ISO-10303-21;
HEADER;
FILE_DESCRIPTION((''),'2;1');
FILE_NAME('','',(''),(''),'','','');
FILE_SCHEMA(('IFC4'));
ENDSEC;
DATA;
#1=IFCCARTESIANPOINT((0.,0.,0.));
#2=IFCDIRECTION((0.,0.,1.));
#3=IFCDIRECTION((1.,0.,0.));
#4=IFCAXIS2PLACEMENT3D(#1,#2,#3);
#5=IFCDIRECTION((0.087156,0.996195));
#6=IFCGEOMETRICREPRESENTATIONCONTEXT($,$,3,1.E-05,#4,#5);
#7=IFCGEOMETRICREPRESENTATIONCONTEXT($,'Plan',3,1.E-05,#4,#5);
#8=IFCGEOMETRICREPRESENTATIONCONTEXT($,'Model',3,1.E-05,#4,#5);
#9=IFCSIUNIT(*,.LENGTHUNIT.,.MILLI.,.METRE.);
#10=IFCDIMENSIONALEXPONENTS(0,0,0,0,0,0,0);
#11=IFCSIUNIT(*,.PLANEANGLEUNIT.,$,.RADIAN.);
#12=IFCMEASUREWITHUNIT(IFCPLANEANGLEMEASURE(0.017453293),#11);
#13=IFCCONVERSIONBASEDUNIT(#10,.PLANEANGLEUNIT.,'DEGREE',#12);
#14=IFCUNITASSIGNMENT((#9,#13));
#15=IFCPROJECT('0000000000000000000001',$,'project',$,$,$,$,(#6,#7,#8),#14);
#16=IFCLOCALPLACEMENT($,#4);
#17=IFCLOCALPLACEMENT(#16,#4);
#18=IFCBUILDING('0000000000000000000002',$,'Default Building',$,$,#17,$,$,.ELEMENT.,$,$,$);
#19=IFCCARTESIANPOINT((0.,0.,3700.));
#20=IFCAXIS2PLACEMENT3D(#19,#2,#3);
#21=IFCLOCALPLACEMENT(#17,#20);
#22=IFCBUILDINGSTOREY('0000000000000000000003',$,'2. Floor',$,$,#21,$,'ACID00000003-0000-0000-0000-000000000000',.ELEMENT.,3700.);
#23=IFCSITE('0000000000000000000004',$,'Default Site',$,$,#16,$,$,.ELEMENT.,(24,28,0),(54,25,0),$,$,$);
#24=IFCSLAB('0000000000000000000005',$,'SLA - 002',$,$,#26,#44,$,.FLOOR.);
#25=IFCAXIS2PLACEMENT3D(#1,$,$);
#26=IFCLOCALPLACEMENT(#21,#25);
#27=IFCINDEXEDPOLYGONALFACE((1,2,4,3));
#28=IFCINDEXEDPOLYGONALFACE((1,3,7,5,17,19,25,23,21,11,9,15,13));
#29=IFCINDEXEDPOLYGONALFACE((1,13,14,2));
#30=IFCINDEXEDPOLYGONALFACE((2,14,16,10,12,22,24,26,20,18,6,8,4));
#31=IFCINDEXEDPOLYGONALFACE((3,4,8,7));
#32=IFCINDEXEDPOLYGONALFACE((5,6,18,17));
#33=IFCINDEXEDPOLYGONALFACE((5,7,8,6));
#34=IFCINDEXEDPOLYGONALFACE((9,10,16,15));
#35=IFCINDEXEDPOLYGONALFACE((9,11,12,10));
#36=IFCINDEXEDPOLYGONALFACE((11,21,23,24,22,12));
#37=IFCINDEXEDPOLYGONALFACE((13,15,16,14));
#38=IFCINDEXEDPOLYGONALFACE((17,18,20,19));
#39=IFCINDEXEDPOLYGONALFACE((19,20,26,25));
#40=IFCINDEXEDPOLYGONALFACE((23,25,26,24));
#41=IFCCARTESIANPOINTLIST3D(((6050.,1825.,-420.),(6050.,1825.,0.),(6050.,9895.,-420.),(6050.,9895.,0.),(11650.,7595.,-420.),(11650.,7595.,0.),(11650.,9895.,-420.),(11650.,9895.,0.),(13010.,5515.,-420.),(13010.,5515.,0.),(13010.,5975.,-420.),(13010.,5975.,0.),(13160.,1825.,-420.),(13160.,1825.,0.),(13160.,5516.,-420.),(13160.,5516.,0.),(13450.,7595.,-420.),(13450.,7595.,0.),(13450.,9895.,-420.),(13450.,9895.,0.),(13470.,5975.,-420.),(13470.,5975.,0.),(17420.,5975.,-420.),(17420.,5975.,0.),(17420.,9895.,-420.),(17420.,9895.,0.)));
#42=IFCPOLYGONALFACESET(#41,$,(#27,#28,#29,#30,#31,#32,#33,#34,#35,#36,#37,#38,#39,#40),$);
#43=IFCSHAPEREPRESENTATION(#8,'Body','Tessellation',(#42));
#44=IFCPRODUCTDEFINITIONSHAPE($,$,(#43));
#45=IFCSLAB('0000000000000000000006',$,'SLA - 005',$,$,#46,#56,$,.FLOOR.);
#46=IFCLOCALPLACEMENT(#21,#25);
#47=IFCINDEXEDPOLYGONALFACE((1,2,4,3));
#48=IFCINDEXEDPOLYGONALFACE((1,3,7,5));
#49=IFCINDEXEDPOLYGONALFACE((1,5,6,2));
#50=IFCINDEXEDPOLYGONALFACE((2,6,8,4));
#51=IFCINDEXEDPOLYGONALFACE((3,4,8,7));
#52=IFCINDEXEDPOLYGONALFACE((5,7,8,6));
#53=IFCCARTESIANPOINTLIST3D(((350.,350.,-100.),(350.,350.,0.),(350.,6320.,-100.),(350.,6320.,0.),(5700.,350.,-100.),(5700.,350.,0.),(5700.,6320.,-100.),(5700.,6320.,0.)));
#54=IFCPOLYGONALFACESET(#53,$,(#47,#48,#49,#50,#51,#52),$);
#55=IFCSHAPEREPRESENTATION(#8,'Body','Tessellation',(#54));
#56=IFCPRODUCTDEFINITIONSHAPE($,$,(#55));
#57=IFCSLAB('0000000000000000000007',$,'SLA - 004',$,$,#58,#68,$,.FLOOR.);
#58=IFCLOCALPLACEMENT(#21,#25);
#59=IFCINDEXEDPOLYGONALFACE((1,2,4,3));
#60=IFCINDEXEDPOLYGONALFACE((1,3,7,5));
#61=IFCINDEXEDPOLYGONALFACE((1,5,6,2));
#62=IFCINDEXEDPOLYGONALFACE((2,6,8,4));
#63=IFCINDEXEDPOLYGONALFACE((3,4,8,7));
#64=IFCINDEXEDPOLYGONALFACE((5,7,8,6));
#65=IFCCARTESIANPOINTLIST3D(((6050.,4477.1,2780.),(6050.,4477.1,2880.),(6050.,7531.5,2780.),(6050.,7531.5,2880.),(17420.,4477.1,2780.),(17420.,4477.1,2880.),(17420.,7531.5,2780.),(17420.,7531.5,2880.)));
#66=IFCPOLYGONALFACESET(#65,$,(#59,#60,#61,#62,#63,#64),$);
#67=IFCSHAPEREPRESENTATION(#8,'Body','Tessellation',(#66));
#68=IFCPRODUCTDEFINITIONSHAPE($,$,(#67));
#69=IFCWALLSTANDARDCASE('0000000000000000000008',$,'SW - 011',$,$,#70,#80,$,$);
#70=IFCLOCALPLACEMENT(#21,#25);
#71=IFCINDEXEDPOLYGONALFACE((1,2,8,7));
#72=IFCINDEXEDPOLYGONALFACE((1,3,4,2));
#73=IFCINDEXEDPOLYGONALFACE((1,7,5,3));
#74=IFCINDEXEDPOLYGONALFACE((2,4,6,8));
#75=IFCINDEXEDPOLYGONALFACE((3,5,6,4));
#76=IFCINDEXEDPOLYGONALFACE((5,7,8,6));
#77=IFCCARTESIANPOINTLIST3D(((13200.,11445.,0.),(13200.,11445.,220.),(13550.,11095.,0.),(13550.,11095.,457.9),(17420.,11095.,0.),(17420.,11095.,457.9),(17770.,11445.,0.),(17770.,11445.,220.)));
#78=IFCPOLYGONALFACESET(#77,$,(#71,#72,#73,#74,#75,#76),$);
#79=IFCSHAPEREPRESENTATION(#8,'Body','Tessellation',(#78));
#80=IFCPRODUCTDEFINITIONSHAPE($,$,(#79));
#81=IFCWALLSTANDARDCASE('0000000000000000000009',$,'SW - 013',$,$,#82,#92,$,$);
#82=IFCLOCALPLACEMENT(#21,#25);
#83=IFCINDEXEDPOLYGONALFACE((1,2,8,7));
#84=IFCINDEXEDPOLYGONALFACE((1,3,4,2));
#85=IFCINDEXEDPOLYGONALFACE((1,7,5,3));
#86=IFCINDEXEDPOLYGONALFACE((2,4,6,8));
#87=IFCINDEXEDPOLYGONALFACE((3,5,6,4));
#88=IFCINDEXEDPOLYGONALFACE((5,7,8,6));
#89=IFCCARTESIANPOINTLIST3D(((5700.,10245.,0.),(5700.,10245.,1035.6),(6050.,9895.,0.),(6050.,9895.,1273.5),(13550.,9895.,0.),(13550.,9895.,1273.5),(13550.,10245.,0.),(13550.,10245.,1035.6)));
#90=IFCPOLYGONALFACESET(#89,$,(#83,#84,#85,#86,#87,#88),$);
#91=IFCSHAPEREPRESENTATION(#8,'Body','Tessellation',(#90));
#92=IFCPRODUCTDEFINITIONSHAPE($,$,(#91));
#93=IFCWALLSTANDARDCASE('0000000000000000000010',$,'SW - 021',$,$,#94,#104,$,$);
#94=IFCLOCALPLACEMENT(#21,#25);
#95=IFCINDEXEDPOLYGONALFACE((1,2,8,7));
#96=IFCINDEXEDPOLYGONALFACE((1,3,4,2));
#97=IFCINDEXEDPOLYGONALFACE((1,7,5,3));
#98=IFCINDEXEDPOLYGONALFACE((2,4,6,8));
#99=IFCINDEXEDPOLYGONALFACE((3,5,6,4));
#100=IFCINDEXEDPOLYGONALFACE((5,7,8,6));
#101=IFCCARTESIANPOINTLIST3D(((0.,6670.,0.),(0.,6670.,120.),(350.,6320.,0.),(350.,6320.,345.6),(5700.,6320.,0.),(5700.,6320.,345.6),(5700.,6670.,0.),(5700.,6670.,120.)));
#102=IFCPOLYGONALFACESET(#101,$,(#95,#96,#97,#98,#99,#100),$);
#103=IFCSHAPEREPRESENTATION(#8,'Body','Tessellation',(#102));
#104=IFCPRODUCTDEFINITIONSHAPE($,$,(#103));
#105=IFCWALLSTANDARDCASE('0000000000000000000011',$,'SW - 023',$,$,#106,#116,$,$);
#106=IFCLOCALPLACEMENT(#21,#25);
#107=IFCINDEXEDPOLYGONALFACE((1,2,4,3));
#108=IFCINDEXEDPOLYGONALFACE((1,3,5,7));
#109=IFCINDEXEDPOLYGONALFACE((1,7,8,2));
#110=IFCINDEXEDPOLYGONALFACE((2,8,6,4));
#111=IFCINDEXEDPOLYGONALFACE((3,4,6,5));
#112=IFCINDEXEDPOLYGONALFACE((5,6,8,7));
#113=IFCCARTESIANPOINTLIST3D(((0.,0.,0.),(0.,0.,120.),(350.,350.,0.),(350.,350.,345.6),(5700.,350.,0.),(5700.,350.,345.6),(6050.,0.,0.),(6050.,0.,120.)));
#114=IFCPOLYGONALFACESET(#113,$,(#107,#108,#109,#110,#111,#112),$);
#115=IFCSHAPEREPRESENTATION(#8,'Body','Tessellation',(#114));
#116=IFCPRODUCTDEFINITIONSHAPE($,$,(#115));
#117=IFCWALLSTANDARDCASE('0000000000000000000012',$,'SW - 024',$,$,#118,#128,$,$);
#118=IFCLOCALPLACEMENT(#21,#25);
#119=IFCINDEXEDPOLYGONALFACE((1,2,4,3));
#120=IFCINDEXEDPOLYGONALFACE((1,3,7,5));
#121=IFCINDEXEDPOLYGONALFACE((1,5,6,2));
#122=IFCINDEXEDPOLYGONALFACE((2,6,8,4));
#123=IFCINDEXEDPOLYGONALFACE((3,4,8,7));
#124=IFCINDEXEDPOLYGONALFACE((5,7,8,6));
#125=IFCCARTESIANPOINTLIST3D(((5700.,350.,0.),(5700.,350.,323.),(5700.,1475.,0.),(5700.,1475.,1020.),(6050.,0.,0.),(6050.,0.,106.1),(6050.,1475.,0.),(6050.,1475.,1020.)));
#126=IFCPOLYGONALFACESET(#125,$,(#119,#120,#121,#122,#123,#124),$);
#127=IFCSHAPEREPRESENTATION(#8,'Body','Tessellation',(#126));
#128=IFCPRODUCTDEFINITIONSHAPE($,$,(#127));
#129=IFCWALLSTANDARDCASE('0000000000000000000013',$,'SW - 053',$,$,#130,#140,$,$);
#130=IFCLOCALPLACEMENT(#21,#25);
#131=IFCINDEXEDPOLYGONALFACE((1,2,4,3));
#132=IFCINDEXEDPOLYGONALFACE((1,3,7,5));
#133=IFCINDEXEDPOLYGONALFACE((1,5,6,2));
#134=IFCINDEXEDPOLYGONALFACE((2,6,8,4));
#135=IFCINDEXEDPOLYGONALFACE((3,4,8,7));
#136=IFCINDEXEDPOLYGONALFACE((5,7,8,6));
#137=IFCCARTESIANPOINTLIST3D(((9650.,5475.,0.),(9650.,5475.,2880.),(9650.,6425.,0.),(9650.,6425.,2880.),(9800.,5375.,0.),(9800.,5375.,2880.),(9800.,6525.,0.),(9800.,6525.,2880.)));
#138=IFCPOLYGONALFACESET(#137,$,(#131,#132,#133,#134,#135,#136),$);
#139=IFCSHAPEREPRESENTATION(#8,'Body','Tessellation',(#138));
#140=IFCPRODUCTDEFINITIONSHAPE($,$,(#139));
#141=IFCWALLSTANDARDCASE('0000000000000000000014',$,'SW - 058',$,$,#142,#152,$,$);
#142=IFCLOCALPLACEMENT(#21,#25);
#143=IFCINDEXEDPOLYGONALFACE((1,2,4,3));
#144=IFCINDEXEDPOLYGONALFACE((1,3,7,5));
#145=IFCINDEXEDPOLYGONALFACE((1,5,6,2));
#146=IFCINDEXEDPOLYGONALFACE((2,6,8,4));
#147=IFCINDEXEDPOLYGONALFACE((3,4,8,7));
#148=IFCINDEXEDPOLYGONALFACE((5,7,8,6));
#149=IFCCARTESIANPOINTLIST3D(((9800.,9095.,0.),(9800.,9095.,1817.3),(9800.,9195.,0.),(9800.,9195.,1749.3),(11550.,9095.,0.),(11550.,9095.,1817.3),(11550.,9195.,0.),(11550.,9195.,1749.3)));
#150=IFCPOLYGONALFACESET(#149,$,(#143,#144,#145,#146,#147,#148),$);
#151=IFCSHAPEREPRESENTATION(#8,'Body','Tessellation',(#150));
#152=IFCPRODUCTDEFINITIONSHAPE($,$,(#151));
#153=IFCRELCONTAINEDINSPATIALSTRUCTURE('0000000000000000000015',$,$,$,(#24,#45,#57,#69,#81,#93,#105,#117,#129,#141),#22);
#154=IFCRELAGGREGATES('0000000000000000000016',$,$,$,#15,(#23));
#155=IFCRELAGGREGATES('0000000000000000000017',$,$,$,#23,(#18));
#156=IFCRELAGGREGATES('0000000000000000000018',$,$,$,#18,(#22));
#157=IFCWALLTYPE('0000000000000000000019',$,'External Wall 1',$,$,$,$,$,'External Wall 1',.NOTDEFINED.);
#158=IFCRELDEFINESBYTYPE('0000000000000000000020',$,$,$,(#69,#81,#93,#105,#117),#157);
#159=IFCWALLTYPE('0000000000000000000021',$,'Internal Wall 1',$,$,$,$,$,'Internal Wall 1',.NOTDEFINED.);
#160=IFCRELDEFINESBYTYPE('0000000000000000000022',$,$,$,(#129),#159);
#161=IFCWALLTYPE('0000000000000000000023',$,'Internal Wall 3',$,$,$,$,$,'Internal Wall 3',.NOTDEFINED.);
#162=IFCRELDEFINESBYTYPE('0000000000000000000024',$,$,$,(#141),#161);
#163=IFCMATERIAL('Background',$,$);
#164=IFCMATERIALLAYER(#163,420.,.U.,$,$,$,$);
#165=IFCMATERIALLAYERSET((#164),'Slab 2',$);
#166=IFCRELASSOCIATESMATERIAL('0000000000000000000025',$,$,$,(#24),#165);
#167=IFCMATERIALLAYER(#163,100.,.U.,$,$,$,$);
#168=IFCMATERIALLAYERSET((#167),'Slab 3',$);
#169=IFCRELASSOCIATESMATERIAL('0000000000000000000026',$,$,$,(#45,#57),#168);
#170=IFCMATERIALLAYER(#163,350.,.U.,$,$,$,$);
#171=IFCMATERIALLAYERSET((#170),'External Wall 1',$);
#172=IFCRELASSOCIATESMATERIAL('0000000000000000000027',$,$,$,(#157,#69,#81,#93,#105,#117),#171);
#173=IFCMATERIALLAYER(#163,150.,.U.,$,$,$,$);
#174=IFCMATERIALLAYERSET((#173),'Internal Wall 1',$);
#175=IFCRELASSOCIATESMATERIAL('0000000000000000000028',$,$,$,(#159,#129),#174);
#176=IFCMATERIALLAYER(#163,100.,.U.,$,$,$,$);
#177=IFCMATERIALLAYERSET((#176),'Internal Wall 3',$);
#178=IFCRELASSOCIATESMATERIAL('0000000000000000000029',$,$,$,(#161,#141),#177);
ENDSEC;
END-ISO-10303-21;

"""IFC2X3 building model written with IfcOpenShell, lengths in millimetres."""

from ifc_helpers import new_model, entity, si_unit, converted_unit, direction, frame, origin_with_axes, place, context, project, spatial, polyline, outline, extrude, clip, halfspace, material, layer, layer_set, layer_usage, type_object, element, save


model = new_model("IFC2X3")

# Units and contexts
context_of_model = context(None, 3, precision=1e-05, world=origin_with_axes(), true_north=direction((0.087156, 0.996195)))
plan_context = context("Plan", 3, precision=1e-05, world=origin_with_axes(), true_north=direction((0.087156, 0.996195)))
model_context = context("Model", 3, precision=1e-05, world=origin_with_axes(), true_north=direction((0.087156, 0.996195)))
ifc_project = project(units=[si_unit("LENGTHUNIT", "METRE", prefix="MILLI"), converted_unit("PLANEANGLEUNIT", "DEGREE", entity("IfcPlaneAngleMeasure", 0.017453293), si_unit("PLANEANGLEUNIT", "RADIAN"), dimensions=[0, 0, 0, 0, 0, 0, 0])], contexts=[context_of_model, plan_context, model_context])

# Site, building, storey
site_placement = place(None, origin_with_axes())
site = spatial("IfcSite", under=ifc_project, at=site_placement, Name="Default Site", CompositionType="ELEMENT", RefLatitude=(24, 28, 0), RefLongitude=(54, 25, 0))
building_placement = place(site_placement, origin_with_axes())
building = spatial("IfcBuilding", under=site, at=building_placement, Name="Default Building", CompositionType="ELEMENT")
storey_placement = place(building_placement, frame((0.0, 0.0, 3700.0), z_axis=(0.0, 0.0, 1.0), x_axis=(1.0, 0.0, 0.0)))
storey = spatial("IfcBuildingStorey", under=building, at=storey_placement, Name="2. Floor", LongName="ACID00000003-0000-0000-0000-000000000000", CompositionType="ELEMENT", Elevation=3700.0)

# Slabs
ifc_material = material(Name="Background")
ifc_layer_1 = layer(ifc_material, 420.0, ventilated="UNKNOWN")
ifc_layer_set_1 = layer_set([ifc_layer_1], Name="Slab 2")
ifc_layer_usage_1 = layer_usage(ifc_layer_set_1, "AXIS3", "NEGATIVE", 420.0)
slab_1_placement = place(storey_placement, frame((13470.0, 5975.0, -420.0), z_axis=(0.0, 0.0, 1.0), x_axis=(1.0, 0.0, 0.0)))
element("IfcSlab", 1, at=slab_1_placement, inside=storey, material=ifc_layer_usage_1, Name="SLA - 002", PredefinedType="FLOOR", context=model_context, shape_type="SweptSolid", body=[
    extrude(outline(polyline([(0.0, 0.0), (3950.0, 0.0), (3950.0, 3920.0), (-20.0, 3920.0), (-20.0, 1620.0), (-1820.0, 1620.0), (-1820.0, 3920.0), (-7420.0, 3920.0), (-7420.0, -4150.0), (-310.0, -4150.0), (-310.0, -459.0), (-460.0, -460.0), (-460.0, 0.0), (0.0, 0.0)])), origin_with_axes(), (0.0, 0.0, 1.0), 420.0),
])
ifc_layer_2 = layer(ifc_material, 100.0, ventilated="UNKNOWN")
ifc_layer_set_2 = layer_set([ifc_layer_2], Name="Slab 3")
ifc_layer_usage_2 = layer_usage(ifc_layer_set_2, "AXIS3", "NEGATIVE", 100.0)
slab_2_placement = place(storey_placement, frame((5700.0, 6320.0, -100.0), z_axis=(0.0, 0.0, 1.0), x_axis=(0.0, -1.0, 0.0)))
element("IfcSlab", 2, at=slab_2_placement, inside=storey, material=ifc_layer_usage_2, Name="SLA - 005", PredefinedType="FLOOR", context=model_context, shape_type="SweptSolid", body=[
    extrude(outline(polyline([(0.0, 0.0), (5970.0, 0.0), (5970.0, -5350.0), (0.0, -5350.0), (0.0, 0.0)])), origin_with_axes(), (0.0, 0.0, 1.0), 100.0),
])
ifc_layer_usage_3 = layer_usage(ifc_layer_set_2, "AXIS3", "NEGATIVE", 100.0)
slab_3_placement = place(storey_placement, frame((6050.0, 7531.5, 2780.0), z_axis=(0.0, 0.0, 1.0), x_axis=(0.0, -1.0, 0.0)))
element("IfcSlab", 3, at=slab_3_placement, inside=storey, material=ifc_layer_usage_3, Name="SLA - 004", PredefinedType="FLOOR", context=model_context, shape_type="SweptSolid", body=[
    extrude(outline(polyline([(0.0, 0.0), (3054.4, 0.0), (3054.4, 11370.0), (0.0, 11370.0), (0.0, 0.0)])), origin_with_axes(), (0.0, 0.0, 1.0), 100.0),
])

# Walls
ifc_layer_3 = layer(ifc_material, 350.0, ventilated="UNKNOWN")
ifc_layer_set_3 = layer_set([ifc_layer_3], Name="External Wall 1")
ifc_layer_usage_4 = layer_usage(ifc_layer_set_3, "AXIS2", "POSITIVE", 0.0)
wall_type_1 = type_object("IfcWallType", Name="External Wall 1", ElementType="External Wall 1", PredefinedType="NOTDEFINED", material=ifc_layer_set_3)
wall_1_placement = place(storey_placement, frame((17770.0, 11445.0, 0.0), z_axis=(0.0, 0.0, 1.0), x_axis=(-1.0, 0.0, 0.0)))
element("IfcWallStandardCase", 4, at=wall_1_placement, inside=storey, type_object=wall_type_1, material=ifc_layer_usage_4, Name="SW - 011", context=model_context, shape_type="Clipping", body=[
    clip(clip(extrude(outline(polyline([(0.0, 0.0), (4570.0, 0.0), (4220.0, 350.0), (350.0, 350.0), (0.0, 0.0)])), origin_with_axes(), (0.0, 0.0, 1.0), 457.9), halfspace(frame((0.0, -102.3, 150.5), z_axis=(0.0, -0.562142, 0.827041), x_axis=(0.0, 0.827041, 0.562142)), False)), halfspace(frame((0.0, -102.3, 150.5), z_axis=(0.0, -0.562142, 0.827041), x_axis=(0.0, 0.827041, 0.562142)), False)),
])
ifc_layer_usage_5 = layer_usage(ifc_layer_set_3, "AXIS2", "POSITIVE", 0.0)
wall_2_placement = place(storey_placement, frame((13550.0, 10245.0, 0.0), z_axis=(0.0, 0.0, 1.0), x_axis=(-1.0, 0.0, 0.0)))
element("IfcWallStandardCase", 5, at=wall_2_placement, inside=storey, type_object=wall_type_1, material=ifc_layer_usage_5, Name="SW - 013", context=model_context, shape_type="Clipping", body=[
    clip(clip(extrude(outline(polyline([(0.0, 0.0), (7850.0, 0.0), (7500.0, 350.0), (0.0, 350.0), (0.0, 0.0)])), origin_with_axes(), (0.0, 0.0, 1.0), 1273.5), halfspace(frame((0.0, -481.5, 708.4), z_axis=(0.0, -0.562142, 0.827041), x_axis=(0.0, 0.827041, 0.562142)), False)), halfspace(frame((0.0, -481.5, 708.4), z_axis=(0.0, -0.562142, 0.827041), x_axis=(0.0, 0.827041, 0.562142)), False)),
])

# Walls
ifc_layer_usage_6 = layer_usage(ifc_layer_set_3, "AXIS2", "POSITIVE", 0.0)
wall_3_placement = place(storey_placement, frame((5700.0, 6670.0, 0.0), z_axis=(0.0, 0.0, 1.0), x_axis=(-1.0, 0.0, 0.0)))
element("IfcWallStandardCase", 6, at=wall_3_placement, inside=storey, type_object=wall_type_1, material=ifc_layer_usage_6, Name="SW - 021", context=model_context, shape_type="Clipping", body=[
    clip(extrude(outline(polyline([(0.0, 0.0), (5700.0, 0.0), (5350.0, 350.0), (0.0, 350.0), (0.0, 0.0)])), origin_with_axes(), (0.0, 0.0, 1.0), 345.6), halfspace(frame((0.0, -54.6, 84.8), z_axis=(0.0, -0.54184, 0.840482), x_axis=(0.0, 0.840482, 0.54184)), False)),
])
ifc_layer_usage_7 = layer_usage(ifc_layer_set_3, "AXIS2", "POSITIVE", 0.0)
wall_4_placement = place(storey_placement, origin_with_axes())
element("IfcWallStandardCase", 7, at=wall_4_placement, inside=storey, type_object=wall_type_1, material=ifc_layer_usage_7, Name="SW - 023", context=model_context, shape_type="Clipping", body=[
    clip(extrude(outline(polyline([(0.0, 0.0), (6050.0, 0.0), (5700.0, 350.0), (350.0, 350.0), (0.0, 0.0)])), origin_with_axes(), (0.0, 0.0, 1.0), 345.6), halfspace(frame((0.0, -54.6, 84.8), z_axis=(0.0, -0.54184, 0.840482), x_axis=(0.0, 0.840482, 0.54184)), False)),
])
ifc_layer_usage_8 = layer_usage(ifc_layer_set_3, "AXIS2", "POSITIVE", 0.0)
wall_5_placement = place(storey_placement, frame((6050.0, 0.0, 0.0), z_axis=(0.0, 0.0, 1.0), x_axis=(0.0, 1.0, 0.0)))
element("IfcWallStandardCase", 8, at=wall_5_placement, inside=storey, type_object=wall_type_1, material=ifc_layer_usage_8, Name="SW - 024", context=model_context, shape_type="Clipping", body=[
    clip(extrude(outline(polyline([(0.0, 0.0), (1475.0, 0.0), (1475.0, 350.0), (350.0, 350.0), (0.0, 0.0)])), origin_with_axes(), (0.0, 0.0, 1.0), 1020.0), halfspace(frame((-47.5, 0.0, 76.7), z_axis=(-0.526673, 0.0, 0.850068), x_axis=(0.0, 1.0, 0.0)), False)),
])
ifc_layer_4 = layer(ifc_material, 150.0, ventilated="UNKNOWN")
ifc_layer_set_4 = layer_set([ifc_layer_4], Name="Internal Wall 1")
wall_type_2 = type_object("IfcWallType", Name="Internal Wall 1", ElementType="Internal Wall 1", PredefinedType="NOTDEFINED", material=ifc_layer_set_4)
ifc_layer_usage_9 = layer_usage(ifc_layer_set_4, "AXIS2", "POSITIVE", 0.0)
wall_6_placement = place(storey_placement, frame((9800.0, 5375.0, 0.0), z_axis=(0.0, 0.0, 1.0), x_axis=(0.0, 1.0, 0.0)))
element("IfcWallStandardCase", 9, at=wall_6_placement, inside=storey, type_object=wall_type_2, material=ifc_layer_usage_9, Name="SW - 053", context=model_context, shape_type="SweptSolid", body=[
    extrude(outline(polyline([(0.0, 0.0), (1150.0, 0.0), (1050.0, 150.0), (100.0, 150.0), (0.0, 0.0)])), origin_with_axes(), (0.0, 0.0, 1.0), 2880.0),
])
ifc_layer_5 = layer(ifc_material, 100.0, ventilated="UNKNOWN")
ifc_layer_set_5 = layer_set([ifc_layer_5], Name="Internal Wall 3")
ifc_layer_usage_10 = layer_usage(ifc_layer_set_5, "AXIS2", "NEGATIVE", 0.0)
wall_type_3 = type_object("IfcWallType", Name="Internal Wall 3", ElementType="Internal Wall 3", PredefinedType="NOTDEFINED", material=ifc_layer_set_5)
wall_7_placement = place(storey_placement, frame((11550.0, 9095.0, 0.0), z_axis=(0.0, 0.0, 1.0), x_axis=(-1.0, 0.0, 0.0)))
element("IfcWallStandardCase", 10, at=wall_7_placement, inside=storey, type_object=wall_type_3, material=ifc_layer_usage_10, Name="SW - 058", context=model_context, shape_type="Clipping", body=[
    clip(clip(extrude(outline(polyline([(0.0, -100.0), (1750.0, -100.0), (1750.0, 0.0), (0.0, 0.0), (0.0, -100.0)])), origin_with_axes(), (0.0, 0.0, 1.0), 1817.3), halfspace(frame((0.0, -844.9, 1243.0), z_axis=(0.0, -0.562142, 0.827041), x_axis=(0.0, 0.827041, 0.562142)), False)), halfspace(frame((0.0, -844.9, 1243.0), z_axis=(0.0, -0.562142, 0.827041), x_axis=(0.0, 0.827041, 0.562142)), False)),
])

save(model, "model.ifc")
